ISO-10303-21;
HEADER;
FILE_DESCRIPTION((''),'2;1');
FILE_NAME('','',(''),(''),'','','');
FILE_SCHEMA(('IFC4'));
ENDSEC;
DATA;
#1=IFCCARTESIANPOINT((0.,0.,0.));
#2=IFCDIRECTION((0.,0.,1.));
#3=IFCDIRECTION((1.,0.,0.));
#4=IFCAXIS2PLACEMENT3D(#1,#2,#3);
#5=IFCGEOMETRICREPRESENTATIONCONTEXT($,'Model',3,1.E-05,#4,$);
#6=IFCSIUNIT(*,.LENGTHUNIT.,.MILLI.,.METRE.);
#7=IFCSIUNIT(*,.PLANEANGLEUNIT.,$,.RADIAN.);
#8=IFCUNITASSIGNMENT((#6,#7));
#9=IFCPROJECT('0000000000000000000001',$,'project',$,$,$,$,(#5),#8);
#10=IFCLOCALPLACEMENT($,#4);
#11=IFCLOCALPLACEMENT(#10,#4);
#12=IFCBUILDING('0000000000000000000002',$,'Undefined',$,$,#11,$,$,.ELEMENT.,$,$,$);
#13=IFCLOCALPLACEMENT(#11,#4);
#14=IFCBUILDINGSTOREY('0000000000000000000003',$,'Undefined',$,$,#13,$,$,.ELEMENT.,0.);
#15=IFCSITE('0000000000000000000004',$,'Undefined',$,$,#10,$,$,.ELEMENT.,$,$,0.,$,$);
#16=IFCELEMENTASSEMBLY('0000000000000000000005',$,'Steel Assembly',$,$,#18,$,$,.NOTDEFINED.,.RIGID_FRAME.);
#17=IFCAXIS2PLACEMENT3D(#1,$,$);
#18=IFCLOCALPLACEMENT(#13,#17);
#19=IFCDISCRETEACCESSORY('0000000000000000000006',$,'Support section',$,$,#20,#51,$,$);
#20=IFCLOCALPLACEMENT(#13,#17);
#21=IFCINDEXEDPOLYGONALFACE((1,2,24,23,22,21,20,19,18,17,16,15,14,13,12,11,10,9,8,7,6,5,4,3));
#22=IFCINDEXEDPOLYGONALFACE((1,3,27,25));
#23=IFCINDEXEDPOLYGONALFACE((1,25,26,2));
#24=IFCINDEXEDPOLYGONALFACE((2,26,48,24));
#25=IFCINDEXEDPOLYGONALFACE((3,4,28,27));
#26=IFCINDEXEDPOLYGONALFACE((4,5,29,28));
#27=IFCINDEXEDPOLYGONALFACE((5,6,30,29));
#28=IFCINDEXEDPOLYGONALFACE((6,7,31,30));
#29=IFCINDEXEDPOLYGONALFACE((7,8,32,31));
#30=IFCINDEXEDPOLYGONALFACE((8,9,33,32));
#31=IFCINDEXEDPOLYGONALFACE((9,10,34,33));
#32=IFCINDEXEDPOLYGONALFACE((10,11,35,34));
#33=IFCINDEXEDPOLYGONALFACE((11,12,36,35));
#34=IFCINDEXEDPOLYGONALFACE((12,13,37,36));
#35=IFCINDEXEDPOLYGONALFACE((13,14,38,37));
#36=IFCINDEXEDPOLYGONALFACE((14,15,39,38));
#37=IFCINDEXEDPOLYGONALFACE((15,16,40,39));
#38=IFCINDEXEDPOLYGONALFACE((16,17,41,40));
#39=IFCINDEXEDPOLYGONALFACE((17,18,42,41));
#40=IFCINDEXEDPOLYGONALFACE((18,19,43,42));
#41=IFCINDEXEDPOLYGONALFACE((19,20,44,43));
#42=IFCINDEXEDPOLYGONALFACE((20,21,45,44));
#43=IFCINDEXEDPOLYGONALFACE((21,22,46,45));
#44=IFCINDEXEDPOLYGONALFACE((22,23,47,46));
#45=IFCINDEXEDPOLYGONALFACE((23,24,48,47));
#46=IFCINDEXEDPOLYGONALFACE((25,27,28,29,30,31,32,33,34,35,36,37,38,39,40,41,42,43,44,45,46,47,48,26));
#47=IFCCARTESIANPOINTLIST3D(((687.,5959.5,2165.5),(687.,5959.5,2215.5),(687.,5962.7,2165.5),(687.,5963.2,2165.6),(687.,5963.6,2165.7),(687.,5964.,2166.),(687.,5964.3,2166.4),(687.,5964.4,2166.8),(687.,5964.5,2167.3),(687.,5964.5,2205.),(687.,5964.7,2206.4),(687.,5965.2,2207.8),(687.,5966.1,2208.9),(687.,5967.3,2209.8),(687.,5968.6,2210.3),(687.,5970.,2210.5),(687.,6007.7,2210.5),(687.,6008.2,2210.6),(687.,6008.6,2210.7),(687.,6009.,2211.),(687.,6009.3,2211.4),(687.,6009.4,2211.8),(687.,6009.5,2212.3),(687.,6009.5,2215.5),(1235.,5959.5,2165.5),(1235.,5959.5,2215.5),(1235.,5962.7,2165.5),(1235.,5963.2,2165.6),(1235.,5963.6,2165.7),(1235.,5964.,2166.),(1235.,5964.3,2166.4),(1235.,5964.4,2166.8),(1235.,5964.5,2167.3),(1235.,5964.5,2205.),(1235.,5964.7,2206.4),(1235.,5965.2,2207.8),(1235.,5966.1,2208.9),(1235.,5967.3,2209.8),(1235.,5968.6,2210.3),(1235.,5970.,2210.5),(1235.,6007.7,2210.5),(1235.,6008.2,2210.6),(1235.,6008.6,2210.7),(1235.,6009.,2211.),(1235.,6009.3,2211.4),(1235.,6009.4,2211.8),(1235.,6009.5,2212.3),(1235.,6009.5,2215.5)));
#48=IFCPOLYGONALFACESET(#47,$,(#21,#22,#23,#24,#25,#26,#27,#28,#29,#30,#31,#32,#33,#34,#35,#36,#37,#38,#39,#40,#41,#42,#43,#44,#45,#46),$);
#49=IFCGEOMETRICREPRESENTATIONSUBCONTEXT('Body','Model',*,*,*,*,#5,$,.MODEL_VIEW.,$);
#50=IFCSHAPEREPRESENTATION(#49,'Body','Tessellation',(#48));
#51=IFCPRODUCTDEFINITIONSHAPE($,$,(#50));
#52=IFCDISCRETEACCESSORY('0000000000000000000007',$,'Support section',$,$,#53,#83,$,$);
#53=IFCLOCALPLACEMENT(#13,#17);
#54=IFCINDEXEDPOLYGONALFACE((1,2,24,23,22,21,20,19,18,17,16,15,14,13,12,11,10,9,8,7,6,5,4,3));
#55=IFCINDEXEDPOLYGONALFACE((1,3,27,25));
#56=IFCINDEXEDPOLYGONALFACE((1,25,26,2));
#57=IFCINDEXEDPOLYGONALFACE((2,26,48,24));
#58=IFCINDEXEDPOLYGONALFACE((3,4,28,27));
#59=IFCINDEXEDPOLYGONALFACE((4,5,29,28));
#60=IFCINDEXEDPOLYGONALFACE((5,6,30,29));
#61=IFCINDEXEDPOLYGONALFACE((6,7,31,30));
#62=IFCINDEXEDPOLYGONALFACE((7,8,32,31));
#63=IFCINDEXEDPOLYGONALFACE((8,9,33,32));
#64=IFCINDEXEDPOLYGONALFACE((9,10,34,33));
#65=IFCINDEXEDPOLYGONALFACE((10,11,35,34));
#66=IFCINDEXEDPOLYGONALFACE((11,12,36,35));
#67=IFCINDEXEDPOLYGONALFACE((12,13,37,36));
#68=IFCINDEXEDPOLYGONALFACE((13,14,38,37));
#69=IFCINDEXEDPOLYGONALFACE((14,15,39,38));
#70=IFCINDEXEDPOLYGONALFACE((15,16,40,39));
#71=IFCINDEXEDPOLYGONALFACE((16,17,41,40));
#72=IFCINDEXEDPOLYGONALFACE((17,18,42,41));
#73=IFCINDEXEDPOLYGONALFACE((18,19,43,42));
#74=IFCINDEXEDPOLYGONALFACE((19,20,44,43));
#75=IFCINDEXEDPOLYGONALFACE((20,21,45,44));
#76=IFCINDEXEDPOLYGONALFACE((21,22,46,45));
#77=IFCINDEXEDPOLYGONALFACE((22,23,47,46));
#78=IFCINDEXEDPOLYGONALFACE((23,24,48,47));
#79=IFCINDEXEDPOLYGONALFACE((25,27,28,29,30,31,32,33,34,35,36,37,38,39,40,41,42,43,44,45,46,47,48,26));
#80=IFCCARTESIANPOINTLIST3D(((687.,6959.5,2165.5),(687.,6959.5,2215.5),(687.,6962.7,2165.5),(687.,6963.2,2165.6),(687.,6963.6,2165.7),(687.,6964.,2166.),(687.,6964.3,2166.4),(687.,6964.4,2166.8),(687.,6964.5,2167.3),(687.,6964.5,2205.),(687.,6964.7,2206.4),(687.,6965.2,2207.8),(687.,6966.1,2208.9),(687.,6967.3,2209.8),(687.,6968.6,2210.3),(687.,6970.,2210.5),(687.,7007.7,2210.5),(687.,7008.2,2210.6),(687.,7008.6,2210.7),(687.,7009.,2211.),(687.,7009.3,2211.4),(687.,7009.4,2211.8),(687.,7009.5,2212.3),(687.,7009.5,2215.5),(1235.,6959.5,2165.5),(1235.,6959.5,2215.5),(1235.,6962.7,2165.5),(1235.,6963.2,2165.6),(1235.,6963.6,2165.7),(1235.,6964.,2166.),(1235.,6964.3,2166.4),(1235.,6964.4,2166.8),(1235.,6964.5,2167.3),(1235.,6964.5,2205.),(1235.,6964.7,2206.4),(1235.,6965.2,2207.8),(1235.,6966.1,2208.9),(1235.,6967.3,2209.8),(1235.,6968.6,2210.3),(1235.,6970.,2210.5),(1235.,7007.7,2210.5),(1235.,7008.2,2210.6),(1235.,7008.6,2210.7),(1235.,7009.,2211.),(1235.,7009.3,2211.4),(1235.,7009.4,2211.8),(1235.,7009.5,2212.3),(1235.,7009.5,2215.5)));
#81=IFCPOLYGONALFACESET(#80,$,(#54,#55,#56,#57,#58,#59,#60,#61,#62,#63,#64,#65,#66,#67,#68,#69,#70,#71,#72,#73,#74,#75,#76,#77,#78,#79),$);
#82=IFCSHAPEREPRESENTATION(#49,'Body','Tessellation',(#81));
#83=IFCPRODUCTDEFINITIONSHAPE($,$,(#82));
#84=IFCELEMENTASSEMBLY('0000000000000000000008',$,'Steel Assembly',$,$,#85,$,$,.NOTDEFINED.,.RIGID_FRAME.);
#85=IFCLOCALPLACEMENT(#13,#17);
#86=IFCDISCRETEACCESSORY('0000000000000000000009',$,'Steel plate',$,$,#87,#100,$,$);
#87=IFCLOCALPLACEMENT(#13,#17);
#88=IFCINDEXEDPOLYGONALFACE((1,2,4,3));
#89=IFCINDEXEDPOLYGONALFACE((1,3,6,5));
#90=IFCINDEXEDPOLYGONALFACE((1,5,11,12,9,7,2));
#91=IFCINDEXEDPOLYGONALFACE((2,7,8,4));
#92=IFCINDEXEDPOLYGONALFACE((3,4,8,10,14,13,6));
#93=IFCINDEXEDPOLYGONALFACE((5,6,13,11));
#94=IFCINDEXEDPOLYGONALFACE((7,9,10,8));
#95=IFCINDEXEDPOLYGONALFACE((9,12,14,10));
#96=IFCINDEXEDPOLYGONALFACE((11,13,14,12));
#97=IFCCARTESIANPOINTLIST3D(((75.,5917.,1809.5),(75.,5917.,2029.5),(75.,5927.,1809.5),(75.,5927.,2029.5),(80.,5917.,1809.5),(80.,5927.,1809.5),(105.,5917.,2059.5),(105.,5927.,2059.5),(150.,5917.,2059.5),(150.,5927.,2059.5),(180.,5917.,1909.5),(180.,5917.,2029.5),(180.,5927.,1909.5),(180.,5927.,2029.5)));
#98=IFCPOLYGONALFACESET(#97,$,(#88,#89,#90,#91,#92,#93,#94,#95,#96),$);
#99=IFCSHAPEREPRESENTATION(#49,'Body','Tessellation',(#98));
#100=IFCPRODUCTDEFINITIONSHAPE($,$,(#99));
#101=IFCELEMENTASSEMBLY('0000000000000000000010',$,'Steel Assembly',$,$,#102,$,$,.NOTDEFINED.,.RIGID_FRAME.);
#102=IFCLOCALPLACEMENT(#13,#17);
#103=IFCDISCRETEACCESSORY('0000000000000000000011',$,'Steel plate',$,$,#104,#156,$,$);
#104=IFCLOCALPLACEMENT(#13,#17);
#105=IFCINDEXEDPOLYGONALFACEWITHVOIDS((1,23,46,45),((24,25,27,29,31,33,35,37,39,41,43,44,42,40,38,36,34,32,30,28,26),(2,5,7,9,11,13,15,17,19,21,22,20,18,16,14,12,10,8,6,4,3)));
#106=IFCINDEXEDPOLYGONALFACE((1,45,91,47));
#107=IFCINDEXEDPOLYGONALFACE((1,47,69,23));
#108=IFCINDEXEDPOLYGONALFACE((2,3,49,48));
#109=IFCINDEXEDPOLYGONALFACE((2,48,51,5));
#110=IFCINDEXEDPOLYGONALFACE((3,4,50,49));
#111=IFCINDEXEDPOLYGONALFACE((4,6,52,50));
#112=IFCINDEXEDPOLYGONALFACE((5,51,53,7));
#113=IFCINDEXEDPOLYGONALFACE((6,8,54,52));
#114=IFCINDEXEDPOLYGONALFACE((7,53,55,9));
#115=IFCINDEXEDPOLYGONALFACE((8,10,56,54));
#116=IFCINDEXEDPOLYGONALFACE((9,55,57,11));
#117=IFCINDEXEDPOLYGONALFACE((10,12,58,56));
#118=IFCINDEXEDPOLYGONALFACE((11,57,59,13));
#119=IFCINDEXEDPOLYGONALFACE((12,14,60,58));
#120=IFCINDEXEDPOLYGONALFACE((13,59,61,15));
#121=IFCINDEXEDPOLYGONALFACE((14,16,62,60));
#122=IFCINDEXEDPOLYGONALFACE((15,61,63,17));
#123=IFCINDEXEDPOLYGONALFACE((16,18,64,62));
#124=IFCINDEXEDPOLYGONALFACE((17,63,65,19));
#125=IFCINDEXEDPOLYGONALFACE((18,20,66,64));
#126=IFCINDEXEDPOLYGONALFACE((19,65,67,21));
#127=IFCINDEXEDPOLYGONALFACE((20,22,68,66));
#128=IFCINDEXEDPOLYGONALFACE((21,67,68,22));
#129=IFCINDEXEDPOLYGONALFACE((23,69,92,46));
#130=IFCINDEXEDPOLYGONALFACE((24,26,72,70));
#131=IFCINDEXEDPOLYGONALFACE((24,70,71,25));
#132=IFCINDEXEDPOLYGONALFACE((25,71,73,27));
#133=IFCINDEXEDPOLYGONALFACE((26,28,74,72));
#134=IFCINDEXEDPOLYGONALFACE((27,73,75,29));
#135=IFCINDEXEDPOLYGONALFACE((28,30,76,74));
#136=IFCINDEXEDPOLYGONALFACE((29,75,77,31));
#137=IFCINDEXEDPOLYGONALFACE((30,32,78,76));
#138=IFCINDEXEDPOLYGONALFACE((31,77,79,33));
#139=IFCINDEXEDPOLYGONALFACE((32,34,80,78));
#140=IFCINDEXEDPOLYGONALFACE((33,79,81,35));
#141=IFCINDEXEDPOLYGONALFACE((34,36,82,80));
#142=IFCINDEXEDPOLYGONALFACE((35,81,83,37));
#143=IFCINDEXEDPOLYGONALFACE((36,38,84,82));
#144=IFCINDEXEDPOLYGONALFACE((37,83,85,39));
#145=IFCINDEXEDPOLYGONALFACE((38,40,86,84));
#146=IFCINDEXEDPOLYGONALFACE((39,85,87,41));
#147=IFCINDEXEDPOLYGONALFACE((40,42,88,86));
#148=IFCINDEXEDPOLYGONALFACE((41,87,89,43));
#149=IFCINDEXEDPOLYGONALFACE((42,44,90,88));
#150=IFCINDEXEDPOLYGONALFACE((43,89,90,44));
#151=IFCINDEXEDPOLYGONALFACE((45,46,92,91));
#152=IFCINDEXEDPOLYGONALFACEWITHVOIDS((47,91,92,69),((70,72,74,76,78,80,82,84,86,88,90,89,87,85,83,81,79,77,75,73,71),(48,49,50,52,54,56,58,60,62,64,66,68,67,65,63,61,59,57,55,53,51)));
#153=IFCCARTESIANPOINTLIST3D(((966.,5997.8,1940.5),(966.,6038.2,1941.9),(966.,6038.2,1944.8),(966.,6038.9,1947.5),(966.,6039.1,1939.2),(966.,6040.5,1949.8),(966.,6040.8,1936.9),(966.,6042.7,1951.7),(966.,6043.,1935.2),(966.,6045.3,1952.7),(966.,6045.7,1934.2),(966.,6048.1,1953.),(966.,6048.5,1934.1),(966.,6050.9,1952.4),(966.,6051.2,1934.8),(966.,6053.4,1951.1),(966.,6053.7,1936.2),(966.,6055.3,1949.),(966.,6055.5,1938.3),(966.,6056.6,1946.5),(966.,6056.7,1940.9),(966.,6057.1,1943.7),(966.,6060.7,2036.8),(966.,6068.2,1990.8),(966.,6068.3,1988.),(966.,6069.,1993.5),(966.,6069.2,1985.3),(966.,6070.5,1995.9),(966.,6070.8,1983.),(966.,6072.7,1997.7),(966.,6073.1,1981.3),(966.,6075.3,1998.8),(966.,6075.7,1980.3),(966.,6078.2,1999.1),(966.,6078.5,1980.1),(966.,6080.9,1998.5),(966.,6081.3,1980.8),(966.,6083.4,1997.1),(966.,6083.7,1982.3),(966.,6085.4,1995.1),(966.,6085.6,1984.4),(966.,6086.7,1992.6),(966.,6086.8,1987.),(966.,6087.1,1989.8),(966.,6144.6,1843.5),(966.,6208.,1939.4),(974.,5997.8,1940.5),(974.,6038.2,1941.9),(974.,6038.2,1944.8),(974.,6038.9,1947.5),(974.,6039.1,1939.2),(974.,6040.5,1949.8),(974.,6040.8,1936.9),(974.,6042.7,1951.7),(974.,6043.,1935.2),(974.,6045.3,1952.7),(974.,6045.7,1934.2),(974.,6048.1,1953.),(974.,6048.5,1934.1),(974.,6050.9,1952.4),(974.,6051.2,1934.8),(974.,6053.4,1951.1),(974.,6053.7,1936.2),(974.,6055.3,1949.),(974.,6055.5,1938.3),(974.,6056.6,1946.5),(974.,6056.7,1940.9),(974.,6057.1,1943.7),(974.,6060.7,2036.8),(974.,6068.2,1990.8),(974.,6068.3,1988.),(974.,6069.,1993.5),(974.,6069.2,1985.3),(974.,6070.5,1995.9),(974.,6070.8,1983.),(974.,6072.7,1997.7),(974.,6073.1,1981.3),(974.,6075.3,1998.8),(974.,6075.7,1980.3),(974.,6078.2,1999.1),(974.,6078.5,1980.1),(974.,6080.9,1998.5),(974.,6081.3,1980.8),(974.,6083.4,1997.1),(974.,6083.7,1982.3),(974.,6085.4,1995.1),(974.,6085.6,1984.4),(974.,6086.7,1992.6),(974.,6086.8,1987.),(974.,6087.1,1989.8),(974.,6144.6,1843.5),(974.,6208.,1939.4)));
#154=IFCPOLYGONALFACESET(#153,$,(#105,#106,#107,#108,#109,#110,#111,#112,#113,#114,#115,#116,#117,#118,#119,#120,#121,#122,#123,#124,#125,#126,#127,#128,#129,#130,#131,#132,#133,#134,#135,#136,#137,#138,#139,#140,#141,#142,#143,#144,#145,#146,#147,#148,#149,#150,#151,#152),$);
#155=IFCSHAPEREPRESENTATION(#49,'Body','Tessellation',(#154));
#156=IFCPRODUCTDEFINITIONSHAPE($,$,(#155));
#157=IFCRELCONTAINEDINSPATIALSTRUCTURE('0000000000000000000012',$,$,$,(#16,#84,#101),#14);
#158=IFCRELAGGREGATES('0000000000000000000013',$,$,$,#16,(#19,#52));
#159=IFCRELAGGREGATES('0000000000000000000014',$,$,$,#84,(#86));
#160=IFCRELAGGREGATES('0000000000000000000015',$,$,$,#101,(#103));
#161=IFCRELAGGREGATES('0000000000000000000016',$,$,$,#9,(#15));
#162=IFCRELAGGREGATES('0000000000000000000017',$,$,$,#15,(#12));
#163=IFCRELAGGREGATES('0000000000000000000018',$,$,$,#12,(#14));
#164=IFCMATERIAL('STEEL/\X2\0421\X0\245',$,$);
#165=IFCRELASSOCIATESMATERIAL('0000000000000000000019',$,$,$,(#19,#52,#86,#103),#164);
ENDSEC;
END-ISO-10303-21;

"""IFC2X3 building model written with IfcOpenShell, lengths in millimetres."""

from ifc_helpers import new_model, si_unit, frame, origin_with_axes, origin_2d_with_axis, place, context, subcontext, project, spatial, polyline, circle, l_section, outline, extrude, source, transform, mapped, material, element, aggregate, save


model = new_model("IFC2X3")

# Units and contexts
model_context = context("Model", 3, precision=1e-05, world=origin_with_axes())
body_context = subcontext(model_context, "Body", "Model", "MODEL_VIEW")
ifc_project = project(units=[si_unit("LENGTHUNIT", "METRE", prefix="MILLI"), si_unit("PLANEANGLEUNIT", "RADIAN")], contexts=[model_context])

# Site, building, storey
site_placement = place(None, origin_with_axes())
site = spatial("IfcSite", under=ifc_project, at=site_placement, Name="Undefined", CompositionType="ELEMENT", RefElevation=0.0)
building_placement = place(site_placement, origin_with_axes())
building = spatial("IfcBuilding", under=site, at=building_placement, Name="Undefined", CompositionType="ELEMENT")
storey_placement = place(building_placement, origin_with_axes())
storey = spatial("IfcBuildingStorey", under=building, at=storey_placement, Name="Undefined", CompositionType="ELEMENT", Elevation=0.0)

# Shared definitions
ifc_material_1 = material(Name="STEEL/С245")

# Element assembly
assembly_1_placement = place(storey_placement, origin_with_axes())
assembly_1 = element("IfcElementAssembly", 1, at=assembly_1_placement, inside=storey, Name="Steel Assembly", AssemblyPlace="NOTDEFINED", PredefinedType="RIGID_FRAME")

# Discrete accessories
discrete_accessory_1_placement = place(assembly_1_placement, frame((1235.0, 5984.5, 2190.5), z_axis=(0.0, 1.0, 0.0), x_axis=(-1.0, 0.0, 0.0)))
discrete_accessory_1 = element("IfcDiscreteAccessory", 2, at=discrete_accessory_1_placement, material=ifc_material_1, Name="Support section", context=body_context, shape_type="SweptSolid", body=[
    extrude(l_section(Depth=50.0, Width=50.0, Thickness=5.0, FilletRadius=5.5, EdgeRadius=1.8, at=origin_2d_with_axis()), frame((548.0, 0.0, 0.0), z_axis=(-1.0, 0.0, 0.0), x_axis=(0.0, -1.0, 0.0)), (0.0, 0.0, 1.0), 548.0),
])
discrete_accessory_2_placement = place(assembly_1_placement, frame((1235.0, 6984.5, 2190.5), z_axis=(0.0, 1.0, 0.0), x_axis=(-1.0, 0.0, 0.0)))
discrete_accessory_2 = element("IfcDiscreteAccessory", 3, at=discrete_accessory_2_placement, material=ifc_material_1, Name="Support section", context=body_context, shape_type="SweptSolid", body=[
    extrude(l_section(Depth=50.0, Width=50.0, Thickness=5.0, FilletRadius=5.5, EdgeRadius=1.8, at=origin_2d_with_axis()), frame((548.0, 0.0, 0.0), z_axis=(-1.0, 0.0, 0.0), x_axis=(0.0, -1.0, 0.0)), (0.0, 0.0, 1.0), 548.0),
])
aggregate(assembly_1, [discrete_accessory_1, discrete_accessory_2])

# Element assembly, discrete accessory
assembly_2_placement = place(storey_placement, origin_with_axes())
assembly_2 = element("IfcElementAssembly", 4, at=assembly_2_placement, inside=storey, Name="Steel Assembly", AssemblyPlace="NOTDEFINED", PredefinedType="RIGID_FRAME")
discrete_accessory_3_placement = place(assembly_2_placement, frame((75.0, 5922.0, 2059.5), z_axis=(0.0, 1.0, 0.0), x_axis=(1.0, 0.0, 0.0)))
discrete_accessory_3 = element("IfcDiscreteAccessory", 5, at=discrete_accessory_3_placement, material=ifc_material_1, Name="Steel plate", context=body_context, shape_type="SweptSolid", body=[
    extrude(outline(polyline([(0.0, 30.0), (30.0, 0.0), (75.0, 0.0), (105.0, 30.0), (105.0, 150.0), (5.0, 250.0), (0.0, 250.0), (0.0, 30.0)])), frame((0.0, 0.0, -5.0), z_axis=(0.0, 0.0, 1.0), x_axis=(1.0, 0.0, 0.0)), (0.0, 0.0, 1.0), 10.0),
])
aggregate(assembly_2, [discrete_accessory_3])

# Element assembly, discrete accessory, opening
assembly_3_placement = place(storey_placement, origin_with_axes())
assembly_3 = element("IfcElementAssembly", 6, at=assembly_3_placement, inside=storey, Name="Steel Assembly", AssemblyPlace="NOTDEFINED", PredefinedType="RIGID_FRAME")
discrete_accessory_4_placement = place(assembly_3_placement, frame((970.0, 6060.7, 2036.8), z_axis=(1.0, 0.0, 0.0), x_axis=(0.0, -0.546313, -0.837581)))
discrete_accessory_4 = element("IfcDiscreteAccessory", 7, at=discrete_accessory_4_placement, material=ifc_material_1, Name="Steel plate", context=body_context, shape_type="SweptSolid", body=[
    extrude(outline(polyline([(0.0, 0.0), (115.0, 0.0), (116.1, 175.9), (1.1, 176.6), (0.0, 0.0)])), frame((0.0, 0.0, -4.0), z_axis=(0.0, 0.0, 1.0), x_axis=(1.0, 0.0, 0.0)), (0.0, 0.0, 1.0), 8.0),
])
shared_shape_1 = source(origin_with_axes(), body_context, "Body", "SweptSolid", [
    extrude(circle(Radius=9.5, at=origin_2d_with_axis()), frame((0.0, -4.1, 0.0), z_axis=(0.0, 1.0, 0.0), x_axis=(1.0, 0.0, 0.0)), (0.0, 0.0, 1.0), 12.3),
])
opening_1_placement = place(assembly_3_placement, frame((970.0, 6062.6, 1966.6), z_axis=(0.0, 0.546313, 0.837581), x_axis=(0.0, 0.837581, -0.546313)))
element("IfcOpeningElement", 8, at=opening_1_placement, cuts=discrete_accessory_4, ObjectType="Opening", context=body_context, shape_type="MappedRepresentation", body=[
    mapped(shared_shape_1, transform((0.0, 0.0, -27.5))),
    mapped(shared_shape_1, transform((0.0, 0.0, 27.5))),
])
aggregate(assembly_3, [discrete_accessory_4])

save(model, "model.ifc")
